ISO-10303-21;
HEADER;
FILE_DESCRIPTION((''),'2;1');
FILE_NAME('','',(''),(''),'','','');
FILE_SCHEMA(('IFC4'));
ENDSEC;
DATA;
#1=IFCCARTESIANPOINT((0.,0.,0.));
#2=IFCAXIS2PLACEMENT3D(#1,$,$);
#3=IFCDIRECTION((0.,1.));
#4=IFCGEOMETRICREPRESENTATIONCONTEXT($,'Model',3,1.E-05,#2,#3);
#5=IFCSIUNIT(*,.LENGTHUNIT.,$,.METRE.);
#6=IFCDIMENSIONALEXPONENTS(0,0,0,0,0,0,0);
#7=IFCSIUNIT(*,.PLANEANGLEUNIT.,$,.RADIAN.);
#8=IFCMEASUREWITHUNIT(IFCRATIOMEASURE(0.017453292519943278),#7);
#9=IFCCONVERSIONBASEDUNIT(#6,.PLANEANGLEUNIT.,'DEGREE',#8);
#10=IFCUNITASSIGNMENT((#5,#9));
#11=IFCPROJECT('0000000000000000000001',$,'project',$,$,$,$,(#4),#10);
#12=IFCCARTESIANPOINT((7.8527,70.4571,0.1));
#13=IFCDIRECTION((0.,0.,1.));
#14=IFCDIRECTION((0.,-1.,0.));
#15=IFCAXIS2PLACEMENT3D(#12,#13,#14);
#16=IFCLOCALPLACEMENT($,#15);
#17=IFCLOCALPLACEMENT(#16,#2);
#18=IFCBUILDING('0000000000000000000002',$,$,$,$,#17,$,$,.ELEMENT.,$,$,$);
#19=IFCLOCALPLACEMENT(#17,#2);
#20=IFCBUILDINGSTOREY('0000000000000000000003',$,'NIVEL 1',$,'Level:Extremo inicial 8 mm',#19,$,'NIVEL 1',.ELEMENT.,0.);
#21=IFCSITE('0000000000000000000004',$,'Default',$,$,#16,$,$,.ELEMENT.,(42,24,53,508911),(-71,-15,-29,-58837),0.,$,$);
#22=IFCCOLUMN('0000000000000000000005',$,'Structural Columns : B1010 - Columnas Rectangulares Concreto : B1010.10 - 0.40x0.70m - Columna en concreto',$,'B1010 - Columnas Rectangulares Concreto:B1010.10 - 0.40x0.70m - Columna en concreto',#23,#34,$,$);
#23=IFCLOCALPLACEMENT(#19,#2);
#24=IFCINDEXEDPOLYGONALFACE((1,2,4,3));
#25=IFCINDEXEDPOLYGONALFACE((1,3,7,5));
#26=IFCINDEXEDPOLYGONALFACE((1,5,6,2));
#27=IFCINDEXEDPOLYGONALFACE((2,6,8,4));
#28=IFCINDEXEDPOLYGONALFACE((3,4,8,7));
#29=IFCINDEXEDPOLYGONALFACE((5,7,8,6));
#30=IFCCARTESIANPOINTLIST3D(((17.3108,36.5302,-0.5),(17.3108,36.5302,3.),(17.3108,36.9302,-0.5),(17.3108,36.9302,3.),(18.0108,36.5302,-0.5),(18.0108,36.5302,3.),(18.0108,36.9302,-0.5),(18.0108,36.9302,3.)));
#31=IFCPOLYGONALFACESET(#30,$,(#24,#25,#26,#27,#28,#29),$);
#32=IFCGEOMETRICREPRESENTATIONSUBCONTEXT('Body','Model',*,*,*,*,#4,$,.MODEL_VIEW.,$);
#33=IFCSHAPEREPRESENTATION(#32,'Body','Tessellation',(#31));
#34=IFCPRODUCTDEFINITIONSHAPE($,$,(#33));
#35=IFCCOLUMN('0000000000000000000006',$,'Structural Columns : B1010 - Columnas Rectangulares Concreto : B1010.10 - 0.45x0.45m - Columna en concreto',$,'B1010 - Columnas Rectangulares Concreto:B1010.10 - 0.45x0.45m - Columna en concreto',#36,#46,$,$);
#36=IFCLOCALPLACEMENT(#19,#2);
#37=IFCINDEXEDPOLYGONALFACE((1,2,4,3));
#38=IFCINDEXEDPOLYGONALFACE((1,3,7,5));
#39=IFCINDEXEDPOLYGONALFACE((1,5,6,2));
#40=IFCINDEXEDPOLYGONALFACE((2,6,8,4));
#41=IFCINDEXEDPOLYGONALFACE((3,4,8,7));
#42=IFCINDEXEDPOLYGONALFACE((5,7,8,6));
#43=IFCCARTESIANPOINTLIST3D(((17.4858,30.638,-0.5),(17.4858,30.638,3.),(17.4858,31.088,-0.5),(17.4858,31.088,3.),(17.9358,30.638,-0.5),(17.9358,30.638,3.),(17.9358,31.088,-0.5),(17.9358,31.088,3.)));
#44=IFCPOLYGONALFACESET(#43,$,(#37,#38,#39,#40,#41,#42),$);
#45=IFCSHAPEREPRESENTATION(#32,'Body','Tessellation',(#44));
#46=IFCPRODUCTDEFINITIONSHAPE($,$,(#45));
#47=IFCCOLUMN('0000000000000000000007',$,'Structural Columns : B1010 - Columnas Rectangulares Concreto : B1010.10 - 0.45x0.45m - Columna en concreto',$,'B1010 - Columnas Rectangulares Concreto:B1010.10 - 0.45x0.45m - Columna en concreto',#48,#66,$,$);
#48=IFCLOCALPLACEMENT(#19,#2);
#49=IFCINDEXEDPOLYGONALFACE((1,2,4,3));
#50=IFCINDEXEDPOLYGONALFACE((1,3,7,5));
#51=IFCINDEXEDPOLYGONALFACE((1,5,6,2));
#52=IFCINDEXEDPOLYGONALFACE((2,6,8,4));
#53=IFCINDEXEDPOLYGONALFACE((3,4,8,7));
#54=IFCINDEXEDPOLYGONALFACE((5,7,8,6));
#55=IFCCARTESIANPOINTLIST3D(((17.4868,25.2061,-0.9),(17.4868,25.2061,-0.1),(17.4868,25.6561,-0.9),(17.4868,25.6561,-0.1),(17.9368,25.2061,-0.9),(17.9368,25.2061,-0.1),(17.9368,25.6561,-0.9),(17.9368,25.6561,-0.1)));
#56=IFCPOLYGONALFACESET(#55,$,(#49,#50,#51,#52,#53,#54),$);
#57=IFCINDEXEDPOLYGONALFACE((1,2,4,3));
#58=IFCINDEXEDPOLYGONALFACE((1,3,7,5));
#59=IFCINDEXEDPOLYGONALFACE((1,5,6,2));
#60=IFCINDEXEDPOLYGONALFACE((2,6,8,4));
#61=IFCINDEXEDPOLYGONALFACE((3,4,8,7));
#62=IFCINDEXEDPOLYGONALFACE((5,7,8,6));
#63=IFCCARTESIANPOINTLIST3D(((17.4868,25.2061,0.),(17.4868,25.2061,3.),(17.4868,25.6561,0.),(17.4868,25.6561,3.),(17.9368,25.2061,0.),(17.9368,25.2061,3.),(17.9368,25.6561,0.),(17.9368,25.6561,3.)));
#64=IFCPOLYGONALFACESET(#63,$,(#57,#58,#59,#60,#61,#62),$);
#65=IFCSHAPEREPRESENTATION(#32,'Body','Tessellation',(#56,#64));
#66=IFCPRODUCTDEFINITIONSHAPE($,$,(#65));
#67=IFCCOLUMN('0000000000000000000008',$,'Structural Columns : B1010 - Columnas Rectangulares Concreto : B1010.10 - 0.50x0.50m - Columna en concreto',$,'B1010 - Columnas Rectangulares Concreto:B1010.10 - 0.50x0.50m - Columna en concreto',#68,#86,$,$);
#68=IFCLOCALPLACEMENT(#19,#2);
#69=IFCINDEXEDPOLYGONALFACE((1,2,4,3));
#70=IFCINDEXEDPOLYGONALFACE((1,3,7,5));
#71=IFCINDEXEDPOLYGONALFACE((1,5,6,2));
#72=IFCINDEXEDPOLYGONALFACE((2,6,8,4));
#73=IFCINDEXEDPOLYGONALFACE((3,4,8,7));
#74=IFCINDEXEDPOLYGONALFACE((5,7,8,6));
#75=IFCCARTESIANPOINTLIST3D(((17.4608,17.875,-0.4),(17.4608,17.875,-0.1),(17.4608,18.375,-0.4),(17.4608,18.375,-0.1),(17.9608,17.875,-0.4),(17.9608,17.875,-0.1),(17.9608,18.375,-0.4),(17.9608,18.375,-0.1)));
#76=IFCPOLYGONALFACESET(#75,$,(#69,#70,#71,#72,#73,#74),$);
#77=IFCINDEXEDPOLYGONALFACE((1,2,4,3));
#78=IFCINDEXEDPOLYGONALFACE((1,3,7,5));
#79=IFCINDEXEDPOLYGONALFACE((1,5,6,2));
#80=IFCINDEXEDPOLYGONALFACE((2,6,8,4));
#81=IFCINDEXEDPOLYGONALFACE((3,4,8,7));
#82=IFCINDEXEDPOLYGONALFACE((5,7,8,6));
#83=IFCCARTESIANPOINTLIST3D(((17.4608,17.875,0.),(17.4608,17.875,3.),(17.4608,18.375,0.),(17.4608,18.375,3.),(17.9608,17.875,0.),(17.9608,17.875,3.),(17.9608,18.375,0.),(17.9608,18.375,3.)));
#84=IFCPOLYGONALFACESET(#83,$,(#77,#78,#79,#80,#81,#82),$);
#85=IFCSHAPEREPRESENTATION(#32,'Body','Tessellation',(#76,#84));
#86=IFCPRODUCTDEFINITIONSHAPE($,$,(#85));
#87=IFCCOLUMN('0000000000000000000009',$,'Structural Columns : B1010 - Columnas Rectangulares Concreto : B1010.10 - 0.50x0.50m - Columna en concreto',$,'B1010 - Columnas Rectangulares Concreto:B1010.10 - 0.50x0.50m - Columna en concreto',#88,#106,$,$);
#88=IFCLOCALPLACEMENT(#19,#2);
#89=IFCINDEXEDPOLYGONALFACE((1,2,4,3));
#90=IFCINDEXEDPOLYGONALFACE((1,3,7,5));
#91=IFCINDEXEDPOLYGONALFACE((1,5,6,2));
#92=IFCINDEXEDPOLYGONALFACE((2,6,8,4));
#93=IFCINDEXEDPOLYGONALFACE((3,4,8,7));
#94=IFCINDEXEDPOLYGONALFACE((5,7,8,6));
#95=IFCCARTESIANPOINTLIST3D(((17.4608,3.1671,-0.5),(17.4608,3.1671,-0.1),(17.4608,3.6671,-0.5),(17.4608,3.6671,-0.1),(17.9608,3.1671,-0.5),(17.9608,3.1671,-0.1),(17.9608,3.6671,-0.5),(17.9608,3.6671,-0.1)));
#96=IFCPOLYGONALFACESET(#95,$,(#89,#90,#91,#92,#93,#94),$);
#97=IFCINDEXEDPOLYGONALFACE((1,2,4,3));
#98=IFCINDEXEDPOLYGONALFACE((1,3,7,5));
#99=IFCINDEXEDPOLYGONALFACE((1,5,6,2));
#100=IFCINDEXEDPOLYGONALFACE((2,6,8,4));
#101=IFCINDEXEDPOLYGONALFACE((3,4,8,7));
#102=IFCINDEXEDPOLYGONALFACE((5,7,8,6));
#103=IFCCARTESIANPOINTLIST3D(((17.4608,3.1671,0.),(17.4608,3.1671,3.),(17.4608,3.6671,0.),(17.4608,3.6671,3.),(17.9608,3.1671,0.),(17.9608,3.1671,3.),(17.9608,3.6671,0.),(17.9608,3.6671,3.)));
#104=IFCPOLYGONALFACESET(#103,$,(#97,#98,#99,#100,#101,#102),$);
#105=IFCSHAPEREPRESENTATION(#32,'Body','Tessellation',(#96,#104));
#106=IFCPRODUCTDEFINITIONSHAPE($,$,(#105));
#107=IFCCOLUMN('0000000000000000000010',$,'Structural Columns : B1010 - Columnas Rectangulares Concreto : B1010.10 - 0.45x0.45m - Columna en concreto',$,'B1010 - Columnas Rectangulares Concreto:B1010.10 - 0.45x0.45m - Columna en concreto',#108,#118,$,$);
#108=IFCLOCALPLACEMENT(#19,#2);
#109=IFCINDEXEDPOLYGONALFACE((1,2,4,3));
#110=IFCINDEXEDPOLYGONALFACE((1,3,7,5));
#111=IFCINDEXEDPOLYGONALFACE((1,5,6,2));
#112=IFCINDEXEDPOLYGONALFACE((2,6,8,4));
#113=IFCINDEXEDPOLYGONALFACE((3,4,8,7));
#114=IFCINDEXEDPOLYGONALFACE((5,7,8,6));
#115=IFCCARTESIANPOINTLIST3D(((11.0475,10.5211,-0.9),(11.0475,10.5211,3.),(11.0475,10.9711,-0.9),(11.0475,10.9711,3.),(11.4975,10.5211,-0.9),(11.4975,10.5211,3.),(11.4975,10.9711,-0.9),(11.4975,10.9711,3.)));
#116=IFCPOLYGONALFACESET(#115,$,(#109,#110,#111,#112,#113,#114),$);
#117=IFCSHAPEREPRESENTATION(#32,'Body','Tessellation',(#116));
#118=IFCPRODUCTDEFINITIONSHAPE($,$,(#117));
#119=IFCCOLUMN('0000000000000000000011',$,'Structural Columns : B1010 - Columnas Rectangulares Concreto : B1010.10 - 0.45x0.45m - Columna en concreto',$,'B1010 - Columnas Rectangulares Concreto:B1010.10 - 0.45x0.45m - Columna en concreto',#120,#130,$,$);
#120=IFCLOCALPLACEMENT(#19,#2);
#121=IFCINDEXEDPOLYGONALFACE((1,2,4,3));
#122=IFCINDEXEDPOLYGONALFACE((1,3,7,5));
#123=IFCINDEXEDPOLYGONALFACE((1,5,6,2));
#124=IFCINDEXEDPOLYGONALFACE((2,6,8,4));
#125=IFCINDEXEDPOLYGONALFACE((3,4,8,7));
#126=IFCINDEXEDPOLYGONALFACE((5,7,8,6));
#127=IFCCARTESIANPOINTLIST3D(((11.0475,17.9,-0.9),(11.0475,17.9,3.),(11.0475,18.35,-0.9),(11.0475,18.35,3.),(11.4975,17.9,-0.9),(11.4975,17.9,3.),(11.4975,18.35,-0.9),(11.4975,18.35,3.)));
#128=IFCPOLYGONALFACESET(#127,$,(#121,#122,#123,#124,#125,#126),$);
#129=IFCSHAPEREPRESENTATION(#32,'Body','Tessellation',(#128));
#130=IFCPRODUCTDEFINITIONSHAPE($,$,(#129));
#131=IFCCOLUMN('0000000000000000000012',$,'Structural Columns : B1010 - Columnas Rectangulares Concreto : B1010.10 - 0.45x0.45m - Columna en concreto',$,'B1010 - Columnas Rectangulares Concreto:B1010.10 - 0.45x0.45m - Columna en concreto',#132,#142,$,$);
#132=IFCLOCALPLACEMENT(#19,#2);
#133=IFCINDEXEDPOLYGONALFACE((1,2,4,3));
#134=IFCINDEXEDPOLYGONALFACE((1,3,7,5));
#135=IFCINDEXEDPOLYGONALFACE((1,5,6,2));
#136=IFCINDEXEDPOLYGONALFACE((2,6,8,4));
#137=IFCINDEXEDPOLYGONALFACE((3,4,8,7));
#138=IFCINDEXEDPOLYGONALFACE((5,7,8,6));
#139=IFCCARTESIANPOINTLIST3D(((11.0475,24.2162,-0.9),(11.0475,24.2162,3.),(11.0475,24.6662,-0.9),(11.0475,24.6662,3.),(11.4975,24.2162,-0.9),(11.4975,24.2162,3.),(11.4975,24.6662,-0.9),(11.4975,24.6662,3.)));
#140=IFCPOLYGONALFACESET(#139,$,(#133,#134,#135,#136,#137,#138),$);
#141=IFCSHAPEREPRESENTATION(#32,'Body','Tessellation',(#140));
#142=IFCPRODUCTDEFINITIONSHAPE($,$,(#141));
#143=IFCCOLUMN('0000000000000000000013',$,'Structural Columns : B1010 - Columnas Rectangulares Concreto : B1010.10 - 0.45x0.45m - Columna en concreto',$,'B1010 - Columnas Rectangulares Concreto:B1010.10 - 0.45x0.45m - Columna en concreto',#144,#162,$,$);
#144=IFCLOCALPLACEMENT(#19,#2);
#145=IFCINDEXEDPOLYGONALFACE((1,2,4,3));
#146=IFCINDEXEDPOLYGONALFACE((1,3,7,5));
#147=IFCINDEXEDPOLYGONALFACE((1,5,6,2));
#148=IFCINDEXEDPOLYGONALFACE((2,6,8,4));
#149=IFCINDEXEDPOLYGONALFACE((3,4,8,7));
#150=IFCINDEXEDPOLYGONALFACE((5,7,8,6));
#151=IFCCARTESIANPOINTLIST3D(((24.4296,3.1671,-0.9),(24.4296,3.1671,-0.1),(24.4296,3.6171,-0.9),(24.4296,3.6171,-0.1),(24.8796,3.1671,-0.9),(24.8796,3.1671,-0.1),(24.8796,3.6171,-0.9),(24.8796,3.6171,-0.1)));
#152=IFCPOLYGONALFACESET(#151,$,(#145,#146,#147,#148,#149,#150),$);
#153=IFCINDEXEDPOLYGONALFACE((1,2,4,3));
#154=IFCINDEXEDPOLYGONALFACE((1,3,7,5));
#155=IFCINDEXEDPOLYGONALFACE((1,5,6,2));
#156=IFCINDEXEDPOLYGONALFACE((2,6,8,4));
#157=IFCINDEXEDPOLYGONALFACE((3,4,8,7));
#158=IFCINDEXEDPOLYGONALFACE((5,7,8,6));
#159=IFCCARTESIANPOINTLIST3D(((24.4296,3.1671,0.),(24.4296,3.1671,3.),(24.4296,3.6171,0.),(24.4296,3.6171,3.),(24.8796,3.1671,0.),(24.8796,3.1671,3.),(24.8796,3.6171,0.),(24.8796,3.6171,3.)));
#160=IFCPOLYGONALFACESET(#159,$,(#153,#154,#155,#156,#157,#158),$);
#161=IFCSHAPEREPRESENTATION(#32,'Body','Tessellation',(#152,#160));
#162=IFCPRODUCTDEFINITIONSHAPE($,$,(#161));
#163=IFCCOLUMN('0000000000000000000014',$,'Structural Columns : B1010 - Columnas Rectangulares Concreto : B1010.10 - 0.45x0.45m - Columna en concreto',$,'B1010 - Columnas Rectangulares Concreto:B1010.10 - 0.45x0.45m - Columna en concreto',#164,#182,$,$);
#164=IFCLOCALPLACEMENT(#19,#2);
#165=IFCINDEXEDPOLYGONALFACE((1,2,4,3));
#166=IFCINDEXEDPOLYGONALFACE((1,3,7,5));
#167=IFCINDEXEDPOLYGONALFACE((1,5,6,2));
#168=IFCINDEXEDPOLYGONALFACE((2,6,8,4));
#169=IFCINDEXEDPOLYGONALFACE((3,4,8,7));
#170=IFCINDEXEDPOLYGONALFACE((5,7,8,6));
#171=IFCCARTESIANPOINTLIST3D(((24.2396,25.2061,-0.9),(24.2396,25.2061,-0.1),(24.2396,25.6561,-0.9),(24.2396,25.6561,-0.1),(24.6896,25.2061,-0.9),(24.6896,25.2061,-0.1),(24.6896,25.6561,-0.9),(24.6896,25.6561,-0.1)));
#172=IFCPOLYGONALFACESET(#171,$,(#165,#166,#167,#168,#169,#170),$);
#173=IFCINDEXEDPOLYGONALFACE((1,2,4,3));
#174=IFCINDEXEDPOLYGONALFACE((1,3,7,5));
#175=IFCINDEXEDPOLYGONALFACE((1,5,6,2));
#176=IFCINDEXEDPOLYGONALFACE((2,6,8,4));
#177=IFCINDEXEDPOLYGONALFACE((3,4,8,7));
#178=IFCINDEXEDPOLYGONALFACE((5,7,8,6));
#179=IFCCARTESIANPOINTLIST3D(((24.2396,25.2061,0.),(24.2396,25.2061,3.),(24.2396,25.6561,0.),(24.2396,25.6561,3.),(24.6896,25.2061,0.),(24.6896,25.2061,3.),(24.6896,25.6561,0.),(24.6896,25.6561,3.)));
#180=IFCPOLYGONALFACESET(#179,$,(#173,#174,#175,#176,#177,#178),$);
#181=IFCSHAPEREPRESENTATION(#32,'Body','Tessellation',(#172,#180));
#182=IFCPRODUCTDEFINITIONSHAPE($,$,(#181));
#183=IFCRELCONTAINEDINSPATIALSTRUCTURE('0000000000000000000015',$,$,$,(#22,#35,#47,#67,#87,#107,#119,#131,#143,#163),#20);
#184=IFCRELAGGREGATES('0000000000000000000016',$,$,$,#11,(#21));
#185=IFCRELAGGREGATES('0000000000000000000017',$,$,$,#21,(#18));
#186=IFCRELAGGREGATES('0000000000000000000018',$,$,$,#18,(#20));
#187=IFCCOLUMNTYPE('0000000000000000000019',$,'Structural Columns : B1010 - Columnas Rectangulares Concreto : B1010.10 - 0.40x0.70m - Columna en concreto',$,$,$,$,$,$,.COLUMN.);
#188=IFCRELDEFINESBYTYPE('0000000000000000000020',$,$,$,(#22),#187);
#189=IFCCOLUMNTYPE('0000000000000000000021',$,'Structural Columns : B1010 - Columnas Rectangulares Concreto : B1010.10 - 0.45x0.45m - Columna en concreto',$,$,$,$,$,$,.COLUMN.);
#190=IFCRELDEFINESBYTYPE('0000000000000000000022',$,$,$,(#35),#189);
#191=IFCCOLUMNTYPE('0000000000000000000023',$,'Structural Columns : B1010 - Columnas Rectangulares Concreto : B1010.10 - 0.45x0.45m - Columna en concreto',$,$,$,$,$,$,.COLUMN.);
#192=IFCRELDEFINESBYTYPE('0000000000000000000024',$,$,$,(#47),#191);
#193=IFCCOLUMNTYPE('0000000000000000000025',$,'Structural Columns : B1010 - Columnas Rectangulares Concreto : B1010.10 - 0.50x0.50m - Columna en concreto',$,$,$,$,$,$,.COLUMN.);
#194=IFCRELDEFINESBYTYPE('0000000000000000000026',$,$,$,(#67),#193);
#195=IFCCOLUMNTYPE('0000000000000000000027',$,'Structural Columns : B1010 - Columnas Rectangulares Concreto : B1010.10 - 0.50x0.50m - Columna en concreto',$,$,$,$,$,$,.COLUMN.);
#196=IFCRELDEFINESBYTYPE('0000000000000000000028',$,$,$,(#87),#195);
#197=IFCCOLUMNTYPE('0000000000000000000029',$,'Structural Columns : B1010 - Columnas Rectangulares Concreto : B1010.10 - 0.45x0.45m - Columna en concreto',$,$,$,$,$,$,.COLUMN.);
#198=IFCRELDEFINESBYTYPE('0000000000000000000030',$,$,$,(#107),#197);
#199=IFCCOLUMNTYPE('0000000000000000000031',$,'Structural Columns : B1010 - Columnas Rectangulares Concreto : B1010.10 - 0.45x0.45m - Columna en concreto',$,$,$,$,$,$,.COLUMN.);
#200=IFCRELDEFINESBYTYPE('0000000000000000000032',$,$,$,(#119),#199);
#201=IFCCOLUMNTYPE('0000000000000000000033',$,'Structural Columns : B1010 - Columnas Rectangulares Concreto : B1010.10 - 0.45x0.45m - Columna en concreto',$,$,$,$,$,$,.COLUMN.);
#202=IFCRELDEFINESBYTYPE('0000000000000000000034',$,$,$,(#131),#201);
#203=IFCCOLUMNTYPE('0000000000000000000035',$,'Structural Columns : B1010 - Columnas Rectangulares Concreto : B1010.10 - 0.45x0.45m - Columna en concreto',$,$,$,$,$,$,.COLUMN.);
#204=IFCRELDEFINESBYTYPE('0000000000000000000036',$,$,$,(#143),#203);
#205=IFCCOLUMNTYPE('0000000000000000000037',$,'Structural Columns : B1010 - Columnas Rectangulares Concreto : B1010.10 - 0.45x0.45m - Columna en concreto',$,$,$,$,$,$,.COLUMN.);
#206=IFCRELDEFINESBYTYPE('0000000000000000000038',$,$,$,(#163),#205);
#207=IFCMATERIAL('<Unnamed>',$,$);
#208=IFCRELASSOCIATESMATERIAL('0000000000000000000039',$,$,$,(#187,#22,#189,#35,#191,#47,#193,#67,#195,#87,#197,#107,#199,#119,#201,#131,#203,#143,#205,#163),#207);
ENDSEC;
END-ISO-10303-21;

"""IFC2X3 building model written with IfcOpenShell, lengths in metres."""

from ifc_helpers import new_model, entity, si_unit, converted_unit, direction, frame, frame_2d, origin, origin_2d_with_axis, place, context, subcontext, project, spatial, rectangle, extrude, source, transform, mapped, material, type_object, type_shapes, element, save


model = new_model("IFC2X3")

# Units and contexts
model_context = context("Model", 3, precision=1e-05, world=origin(), true_north=direction((0.0, 1.0)))
body_context = subcontext(model_context, "Body", "Model", "MODEL_VIEW")
ifc_project = project(units=[si_unit("LENGTHUNIT", "METRE"), converted_unit("PLANEANGLEUNIT", "DEGREE", entity("IfcRatioMeasure", 0.017453292519943278), si_unit("PLANEANGLEUNIT", "RADIAN"), dimensions=[0, 0, 0, 0, 0, 0, 0])], contexts=[model_context])

# Site, building, storey
site_placement = place(None, frame((7.8527, 70.4571, 0.1), z_axis=(0.0, 0.0, 1.0), x_axis=(0.0, -1.0, 0.0)))
site = spatial("IfcSite", under=ifc_project, at=site_placement, Name="Default", CompositionType="ELEMENT", RefLatitude=(42, 24, 53, 508911), RefLongitude=(-71, -15, -29, -58837), RefElevation=0.0)
building_placement = place(site_placement, origin())
building = spatial("IfcBuilding", under=site, at=building_placement, CompositionType="ELEMENT")
storey_placement = place(building_placement, origin())
storey = spatial("IfcBuildingStorey", under=building, at=storey_placement, Name="NIVEL 1", ObjectType="Level:Extremo inicial 8 mm", LongName="NIVEL 1", CompositionType="ELEMENT", Elevation=0.0)

# Columns
ifc_material_1 = material(Name="<Unnamed>")
column_type_1 = type_object("IfcColumnType", Name="Structural Columns : B1010 - Columnas Rectangulares Concreto : B1010.10 - 0.40x0.70m - Columna en concreto", PredefinedType="COLUMN", material=ifc_material_1)
shared_shape_1 = source(origin(), body_context, "Body", "SweptSolid", [
    extrude(rectangle(XDim=0.4, YDim=0.7, at=origin_2d_with_axis()), frame((17.6608, 36.7302, -0.5), z_axis=(0.0, 0.0, 1.0), x_axis=(0.0, -1.0, 0.0)), (0.0, 0.0, 1.0), 3.5),
])
type_shapes(column_type_1, [shared_shape_1])
column_1_placement = place(storey_placement, origin())
element("IfcColumn", 1, at=column_1_placement, inside=storey, type_object=column_type_1, material=ifc_material_1, Name="Structural Columns : B1010 - Columnas Rectangulares Concreto : B1010.10 - 0.40x0.70m - Columna en concreto", ObjectType="B1010 - Columnas Rectangulares Concreto:B1010.10 - 0.40x0.70m - Columna en concreto", context=body_context, shape_type="MappedRepresentation", body=[
    mapped(shared_shape_1, transform((0.0, 0.0, 0.0), scale=1.0)),
])
column_type_2 = type_object("IfcColumnType", Name="Structural Columns : B1010 - Columnas Rectangulares Concreto : B1010.10 - 0.45x0.45m - Columna en concreto", PredefinedType="COLUMN", material=ifc_material_1)
shared_shape_2 = source(origin(), body_context, "Body", "SweptSolid", [
    extrude(rectangle(XDim=0.45, YDim=0.45, at=origin_2d_with_axis()), frame((17.7108, 30.863, -0.5), z_axis=(0.0, 0.0, 1.0), x_axis=(0.0, -1.0, 0.0)), (0.0, 0.0, 1.0), 3.5),
])
type_shapes(column_type_2, [shared_shape_2])
column_2_placement = place(storey_placement, origin())
element("IfcColumn", 2, at=column_2_placement, inside=storey, type_object=column_type_2, material=ifc_material_1, Name="Structural Columns : B1010 - Columnas Rectangulares Concreto : B1010.10 - 0.45x0.45m - Columna en concreto", ObjectType="B1010 - Columnas Rectangulares Concreto:B1010.10 - 0.45x0.45m - Columna en concreto", context=body_context, shape_type="MappedRepresentation", body=[
    mapped(shared_shape_2, transform((0.0, 0.0, 0.0), scale=1.0)),
])
column_type_3 = type_object("IfcColumnType", Name="Structural Columns : B1010 - Columnas Rectangulares Concreto : B1010.10 - 0.45x0.45m - Columna en concreto", PredefinedType="COLUMN", material=ifc_material_1)
shared_shape_3 = source(origin(), body_context, "Body", "SweptSolid", [
    extrude(rectangle(XDim=0.45, YDim=0.45, at=origin_2d_with_axis()), frame((17.7118, 25.4311, -0.9), z_axis=(0.0, 0.0, 1.0), x_axis=(0.0, -1.0, 0.0)), (0.0, 0.0, 1.0), 0.8),
    extrude(rectangle(XDim=0.45, YDim=0.45, at=origin_2d_with_axis()), frame((17.7118, 25.4311, 0.0), z_axis=(0.0, 0.0, 1.0), x_axis=(0.0, -1.0, 0.0)), (0.0, 0.0, 1.0), 3.0),
])
type_shapes(column_type_3, [shared_shape_3])
column_3_placement = place(storey_placement, origin())
element("IfcColumn", 3, at=column_3_placement, inside=storey, type_object=column_type_3, material=ifc_material_1, Name="Structural Columns : B1010 - Columnas Rectangulares Concreto : B1010.10 - 0.45x0.45m - Columna en concreto", ObjectType="B1010 - Columnas Rectangulares Concreto:B1010.10 - 0.45x0.45m - Columna en concreto", context=body_context, shape_type="MappedRepresentation", body=[
    mapped(shared_shape_3, transform((0.0, 0.0, 0.0), scale=1.0)),
])
column_type_4 = type_object("IfcColumnType", Name="Structural Columns : B1010 - Columnas Rectangulares Concreto : B1010.10 - 0.50x0.50m - Columna en concreto", PredefinedType="COLUMN", material=ifc_material_1)
shared_shape_4 = source(origin(), body_context, "Body", "SweptSolid", [
    extrude(rectangle(XDim=0.5, YDim=0.5, at=origin_2d_with_axis()), frame((17.7108, 18.125, -0.4), z_axis=(0.0, 0.0, 1.0), x_axis=(0.0, -1.0, 0.0)), (0.0, 0.0, 1.0), 0.3),
    extrude(rectangle(XDim=0.5, YDim=0.5, at=origin_2d_with_axis()), frame((17.7108, 18.125, 0.0), z_axis=(0.0, 0.0, 1.0), x_axis=(0.0, -1.0, 0.0)), (0.0, 0.0, 1.0), 3.0),
])
type_shapes(column_type_4, [shared_shape_4])
column_4_placement = place(storey_placement, origin())
element("IfcColumn", 4, at=column_4_placement, inside=storey, type_object=column_type_4, material=ifc_material_1, Name="Structural Columns : B1010 - Columnas Rectangulares Concreto : B1010.10 - 0.50x0.50m - Columna en concreto", ObjectType="B1010 - Columnas Rectangulares Concreto:B1010.10 - 0.50x0.50m - Columna en concreto", context=body_context, shape_type="MappedRepresentation", body=[
    mapped(shared_shape_4, transform((0.0, 0.0, 0.0), scale=1.0)),
])
column_type_5 = type_object("IfcColumnType", Name="Structural Columns : B1010 - Columnas Rectangulares Concreto : B1010.10 - 0.50x0.50m - Columna en concreto", PredefinedType="COLUMN", material=ifc_material_1)
shared_shape_5 = source(origin(), body_context, "Body", "SweptSolid", [
    extrude(rectangle(XDim=0.5, YDim=0.5, at=origin_2d_with_axis()), frame((17.7108, 3.4171, -0.5), z_axis=(0.0, 0.0, 1.0), x_axis=(0.0, -1.0, 0.0)), (0.0, 0.0, 1.0), 0.4),
    extrude(rectangle(XDim=0.5, YDim=0.5, at=origin_2d_with_axis()), frame((17.7108, 3.4171, 0.0), z_axis=(0.0, 0.0, 1.0), x_axis=(0.0, -1.0, 0.0)), (0.0, 0.0, 1.0), 3.0),
])
type_shapes(column_type_5, [shared_shape_5])
column_5_placement = place(storey_placement, origin())
element("IfcColumn", 5, at=column_5_placement, inside=storey, type_object=column_type_5, material=ifc_material_1, Name="Structural Columns : B1010 - Columnas Rectangulares Concreto : B1010.10 - 0.50x0.50m - Columna en concreto", ObjectType="B1010 - Columnas Rectangulares Concreto:B1010.10 - 0.50x0.50m - Columna en concreto", context=body_context, shape_type="MappedRepresentation", body=[
    mapped(shared_shape_5, transform((0.0, 0.0, 0.0), scale=1.0)),
])
column_type_6 = type_object("IfcColumnType", Name="Structural Columns : B1010 - Columnas Rectangulares Concreto : B1010.10 - 0.45x0.45m - Columna en concreto", PredefinedType="COLUMN", material=ifc_material_1)
shared_shape_6 = source(origin(), body_context, "Body", "SweptSolid", [
    extrude(rectangle(XDim=0.45, YDim=0.45, at=origin_2d_with_axis()), frame((11.2725, 10.7461, -0.9), z_axis=(0.0, 0.0, 1.0), x_axis=(0.0, -1.0, 0.0)), (0.0, 0.0, 1.0), 3.9),
])
type_shapes(column_type_6, [shared_shape_6])
column_6_placement = place(storey_placement, origin())
element("IfcColumn", 6, at=column_6_placement, inside=storey, type_object=column_type_6, material=ifc_material_1, Name="Structural Columns : B1010 - Columnas Rectangulares Concreto : B1010.10 - 0.45x0.45m - Columna en concreto", ObjectType="B1010 - Columnas Rectangulares Concreto:B1010.10 - 0.45x0.45m - Columna en concreto", context=body_context, shape_type="MappedRepresentation", body=[
    mapped(shared_shape_6, transform((0.0, 0.0, 0.0), scale=1.0)),
])
column_type_7 = type_object("IfcColumnType", Name="Structural Columns : B1010 - Columnas Rectangulares Concreto : B1010.10 - 0.45x0.45m - Columna en concreto", PredefinedType="COLUMN", material=ifc_material_1)
shared_shape_7 = source(origin(), body_context, "Body", "SweptSolid", [
    extrude(rectangle(XDim=0.45, YDim=0.45, at=origin_2d_with_axis()), frame((11.2725, 18.125, -0.9), z_axis=(0.0, 0.0, 1.0), x_axis=(0.0, -1.0, 0.0)), (0.0, 0.0, 1.0), 3.9),
])
type_shapes(column_type_7, [shared_shape_7])
column_7_placement = place(storey_placement, origin())
element("IfcColumn", 7, at=column_7_placement, inside=storey, type_object=column_type_7, material=ifc_material_1, Name="Structural Columns : B1010 - Columnas Rectangulares Concreto : B1010.10 - 0.45x0.45m - Columna en concreto", ObjectType="B1010 - Columnas Rectangulares Concreto:B1010.10 - 0.45x0.45m - Columna en concreto", context=body_context, shape_type="MappedRepresentation", body=[
    mapped(shared_shape_7, transform((0.0, 0.0, 0.0), scale=1.0)),
])
column_type_8 = type_object("IfcColumnType", Name="Structural Columns : B1010 - Columnas Rectangulares Concreto : B1010.10 - 0.45x0.45m - Columna en concreto", PredefinedType="COLUMN", material=ifc_material_1)
shared_shape_8 = source(origin(), body_context, "Body", "SweptSolid", [
    extrude(rectangle(XDim=0.45, YDim=0.45, at=origin_2d_with_axis()), frame((11.2725, 24.4412, -0.9), z_axis=(0.0, 0.0, 1.0), x_axis=(0.0, -1.0, 0.0)), (0.0, 0.0, 1.0), 3.9),
])
type_shapes(column_type_8, [shared_shape_8])
column_8_placement = place(storey_placement, origin())
element("IfcColumn", 8, at=column_8_placement, inside=storey, type_object=column_type_8, material=ifc_material_1, Name="Structural Columns : B1010 - Columnas Rectangulares Concreto : B1010.10 - 0.45x0.45m - Columna en concreto", ObjectType="B1010 - Columnas Rectangulares Concreto:B1010.10 - 0.45x0.45m - Columna en concreto", context=body_context, shape_type="MappedRepresentation", body=[
    mapped(shared_shape_8, transform((0.0, 0.0, 0.0), scale=1.0)),
])
column_type_9 = type_object("IfcColumnType", Name="Structural Columns : B1010 - Columnas Rectangulares Concreto : B1010.10 - 0.45x0.45m - Columna en concreto", PredefinedType="COLUMN", material=ifc_material_1)
shared_shape_9 = source(origin(), body_context, "Body", "SweptSolid", [
    extrude(rectangle(XDim=0.45, YDim=0.45, at=frame_2d((0.0, 0.0), x_axis=(1.0, 0.0))), frame((24.6546, 3.3921, -0.9), z_axis=(0.0, 0.0, 1.0), x_axis=(0.0, -1.0, 0.0)), (0.0, 0.0, 1.0), 0.8),
    extrude(rectangle(XDim=0.45, YDim=0.45, at=frame_2d((0.0, 0.0), x_axis=(1.0, 0.0))), frame((24.6546, 3.3921, 0.0), z_axis=(0.0, 0.0, 1.0), x_axis=(0.0, -1.0, 0.0)), (0.0, 0.0, 1.0), 3.0),
])
type_shapes(column_type_9, [shared_shape_9])
column_9_placement = place(storey_placement, origin())
element("IfcColumn", 9, at=column_9_placement, inside=storey, type_object=column_type_9, material=ifc_material_1, Name="Structural Columns : B1010 - Columnas Rectangulares Concreto : B1010.10 - 0.45x0.45m - Columna en concreto", ObjectType="B1010 - Columnas Rectangulares Concreto:B1010.10 - 0.45x0.45m - Columna en concreto", context=body_context, shape_type="MappedRepresentation", body=[
    mapped(shared_shape_9, transform((0.0, 0.0, 0.0), scale=1.0)),
])
column_type_10 = type_object("IfcColumnType", Name="Structural Columns : B1010 - Columnas Rectangulares Concreto : B1010.10 - 0.45x0.45m - Columna en concreto", PredefinedType="COLUMN", material=ifc_material_1)
shared_shape_10 = source(origin(), body_context, "Body", "SweptSolid", [
    extrude(rectangle(XDim=0.45, YDim=0.45, at=origin_2d_with_axis()), frame((24.4646, 25.4311, -0.9), z_axis=(0.0, 0.0, 1.0), x_axis=(0.0, -1.0, 0.0)), (0.0, 0.0, 1.0), 0.8),
    extrude(rectangle(XDim=0.45, YDim=0.45, at=origin_2d_with_axis()), frame((24.4646, 25.4311, 0.0), z_axis=(0.0, 0.0, 1.0), x_axis=(0.0, -1.0, 0.0)), (0.0, 0.0, 1.0), 3.0),
])
type_shapes(column_type_10, [shared_shape_10])
column_10_placement = place(storey_placement, origin())
element("IfcColumn", 10, at=column_10_placement, inside=storey, type_object=column_type_10, material=ifc_material_1, Name="Structural Columns : B1010 - Columnas Rectangulares Concreto : B1010.10 - 0.45x0.45m - Columna en concreto", ObjectType="B1010 - Columnas Rectangulares Concreto:B1010.10 - 0.45x0.45m - Columna en concreto", context=body_context, shape_type="MappedRepresentation", body=[
    mapped(shared_shape_10, transform((0.0, 0.0, 0.0), scale=1.0)),
])

save(model, "model.ifc")
